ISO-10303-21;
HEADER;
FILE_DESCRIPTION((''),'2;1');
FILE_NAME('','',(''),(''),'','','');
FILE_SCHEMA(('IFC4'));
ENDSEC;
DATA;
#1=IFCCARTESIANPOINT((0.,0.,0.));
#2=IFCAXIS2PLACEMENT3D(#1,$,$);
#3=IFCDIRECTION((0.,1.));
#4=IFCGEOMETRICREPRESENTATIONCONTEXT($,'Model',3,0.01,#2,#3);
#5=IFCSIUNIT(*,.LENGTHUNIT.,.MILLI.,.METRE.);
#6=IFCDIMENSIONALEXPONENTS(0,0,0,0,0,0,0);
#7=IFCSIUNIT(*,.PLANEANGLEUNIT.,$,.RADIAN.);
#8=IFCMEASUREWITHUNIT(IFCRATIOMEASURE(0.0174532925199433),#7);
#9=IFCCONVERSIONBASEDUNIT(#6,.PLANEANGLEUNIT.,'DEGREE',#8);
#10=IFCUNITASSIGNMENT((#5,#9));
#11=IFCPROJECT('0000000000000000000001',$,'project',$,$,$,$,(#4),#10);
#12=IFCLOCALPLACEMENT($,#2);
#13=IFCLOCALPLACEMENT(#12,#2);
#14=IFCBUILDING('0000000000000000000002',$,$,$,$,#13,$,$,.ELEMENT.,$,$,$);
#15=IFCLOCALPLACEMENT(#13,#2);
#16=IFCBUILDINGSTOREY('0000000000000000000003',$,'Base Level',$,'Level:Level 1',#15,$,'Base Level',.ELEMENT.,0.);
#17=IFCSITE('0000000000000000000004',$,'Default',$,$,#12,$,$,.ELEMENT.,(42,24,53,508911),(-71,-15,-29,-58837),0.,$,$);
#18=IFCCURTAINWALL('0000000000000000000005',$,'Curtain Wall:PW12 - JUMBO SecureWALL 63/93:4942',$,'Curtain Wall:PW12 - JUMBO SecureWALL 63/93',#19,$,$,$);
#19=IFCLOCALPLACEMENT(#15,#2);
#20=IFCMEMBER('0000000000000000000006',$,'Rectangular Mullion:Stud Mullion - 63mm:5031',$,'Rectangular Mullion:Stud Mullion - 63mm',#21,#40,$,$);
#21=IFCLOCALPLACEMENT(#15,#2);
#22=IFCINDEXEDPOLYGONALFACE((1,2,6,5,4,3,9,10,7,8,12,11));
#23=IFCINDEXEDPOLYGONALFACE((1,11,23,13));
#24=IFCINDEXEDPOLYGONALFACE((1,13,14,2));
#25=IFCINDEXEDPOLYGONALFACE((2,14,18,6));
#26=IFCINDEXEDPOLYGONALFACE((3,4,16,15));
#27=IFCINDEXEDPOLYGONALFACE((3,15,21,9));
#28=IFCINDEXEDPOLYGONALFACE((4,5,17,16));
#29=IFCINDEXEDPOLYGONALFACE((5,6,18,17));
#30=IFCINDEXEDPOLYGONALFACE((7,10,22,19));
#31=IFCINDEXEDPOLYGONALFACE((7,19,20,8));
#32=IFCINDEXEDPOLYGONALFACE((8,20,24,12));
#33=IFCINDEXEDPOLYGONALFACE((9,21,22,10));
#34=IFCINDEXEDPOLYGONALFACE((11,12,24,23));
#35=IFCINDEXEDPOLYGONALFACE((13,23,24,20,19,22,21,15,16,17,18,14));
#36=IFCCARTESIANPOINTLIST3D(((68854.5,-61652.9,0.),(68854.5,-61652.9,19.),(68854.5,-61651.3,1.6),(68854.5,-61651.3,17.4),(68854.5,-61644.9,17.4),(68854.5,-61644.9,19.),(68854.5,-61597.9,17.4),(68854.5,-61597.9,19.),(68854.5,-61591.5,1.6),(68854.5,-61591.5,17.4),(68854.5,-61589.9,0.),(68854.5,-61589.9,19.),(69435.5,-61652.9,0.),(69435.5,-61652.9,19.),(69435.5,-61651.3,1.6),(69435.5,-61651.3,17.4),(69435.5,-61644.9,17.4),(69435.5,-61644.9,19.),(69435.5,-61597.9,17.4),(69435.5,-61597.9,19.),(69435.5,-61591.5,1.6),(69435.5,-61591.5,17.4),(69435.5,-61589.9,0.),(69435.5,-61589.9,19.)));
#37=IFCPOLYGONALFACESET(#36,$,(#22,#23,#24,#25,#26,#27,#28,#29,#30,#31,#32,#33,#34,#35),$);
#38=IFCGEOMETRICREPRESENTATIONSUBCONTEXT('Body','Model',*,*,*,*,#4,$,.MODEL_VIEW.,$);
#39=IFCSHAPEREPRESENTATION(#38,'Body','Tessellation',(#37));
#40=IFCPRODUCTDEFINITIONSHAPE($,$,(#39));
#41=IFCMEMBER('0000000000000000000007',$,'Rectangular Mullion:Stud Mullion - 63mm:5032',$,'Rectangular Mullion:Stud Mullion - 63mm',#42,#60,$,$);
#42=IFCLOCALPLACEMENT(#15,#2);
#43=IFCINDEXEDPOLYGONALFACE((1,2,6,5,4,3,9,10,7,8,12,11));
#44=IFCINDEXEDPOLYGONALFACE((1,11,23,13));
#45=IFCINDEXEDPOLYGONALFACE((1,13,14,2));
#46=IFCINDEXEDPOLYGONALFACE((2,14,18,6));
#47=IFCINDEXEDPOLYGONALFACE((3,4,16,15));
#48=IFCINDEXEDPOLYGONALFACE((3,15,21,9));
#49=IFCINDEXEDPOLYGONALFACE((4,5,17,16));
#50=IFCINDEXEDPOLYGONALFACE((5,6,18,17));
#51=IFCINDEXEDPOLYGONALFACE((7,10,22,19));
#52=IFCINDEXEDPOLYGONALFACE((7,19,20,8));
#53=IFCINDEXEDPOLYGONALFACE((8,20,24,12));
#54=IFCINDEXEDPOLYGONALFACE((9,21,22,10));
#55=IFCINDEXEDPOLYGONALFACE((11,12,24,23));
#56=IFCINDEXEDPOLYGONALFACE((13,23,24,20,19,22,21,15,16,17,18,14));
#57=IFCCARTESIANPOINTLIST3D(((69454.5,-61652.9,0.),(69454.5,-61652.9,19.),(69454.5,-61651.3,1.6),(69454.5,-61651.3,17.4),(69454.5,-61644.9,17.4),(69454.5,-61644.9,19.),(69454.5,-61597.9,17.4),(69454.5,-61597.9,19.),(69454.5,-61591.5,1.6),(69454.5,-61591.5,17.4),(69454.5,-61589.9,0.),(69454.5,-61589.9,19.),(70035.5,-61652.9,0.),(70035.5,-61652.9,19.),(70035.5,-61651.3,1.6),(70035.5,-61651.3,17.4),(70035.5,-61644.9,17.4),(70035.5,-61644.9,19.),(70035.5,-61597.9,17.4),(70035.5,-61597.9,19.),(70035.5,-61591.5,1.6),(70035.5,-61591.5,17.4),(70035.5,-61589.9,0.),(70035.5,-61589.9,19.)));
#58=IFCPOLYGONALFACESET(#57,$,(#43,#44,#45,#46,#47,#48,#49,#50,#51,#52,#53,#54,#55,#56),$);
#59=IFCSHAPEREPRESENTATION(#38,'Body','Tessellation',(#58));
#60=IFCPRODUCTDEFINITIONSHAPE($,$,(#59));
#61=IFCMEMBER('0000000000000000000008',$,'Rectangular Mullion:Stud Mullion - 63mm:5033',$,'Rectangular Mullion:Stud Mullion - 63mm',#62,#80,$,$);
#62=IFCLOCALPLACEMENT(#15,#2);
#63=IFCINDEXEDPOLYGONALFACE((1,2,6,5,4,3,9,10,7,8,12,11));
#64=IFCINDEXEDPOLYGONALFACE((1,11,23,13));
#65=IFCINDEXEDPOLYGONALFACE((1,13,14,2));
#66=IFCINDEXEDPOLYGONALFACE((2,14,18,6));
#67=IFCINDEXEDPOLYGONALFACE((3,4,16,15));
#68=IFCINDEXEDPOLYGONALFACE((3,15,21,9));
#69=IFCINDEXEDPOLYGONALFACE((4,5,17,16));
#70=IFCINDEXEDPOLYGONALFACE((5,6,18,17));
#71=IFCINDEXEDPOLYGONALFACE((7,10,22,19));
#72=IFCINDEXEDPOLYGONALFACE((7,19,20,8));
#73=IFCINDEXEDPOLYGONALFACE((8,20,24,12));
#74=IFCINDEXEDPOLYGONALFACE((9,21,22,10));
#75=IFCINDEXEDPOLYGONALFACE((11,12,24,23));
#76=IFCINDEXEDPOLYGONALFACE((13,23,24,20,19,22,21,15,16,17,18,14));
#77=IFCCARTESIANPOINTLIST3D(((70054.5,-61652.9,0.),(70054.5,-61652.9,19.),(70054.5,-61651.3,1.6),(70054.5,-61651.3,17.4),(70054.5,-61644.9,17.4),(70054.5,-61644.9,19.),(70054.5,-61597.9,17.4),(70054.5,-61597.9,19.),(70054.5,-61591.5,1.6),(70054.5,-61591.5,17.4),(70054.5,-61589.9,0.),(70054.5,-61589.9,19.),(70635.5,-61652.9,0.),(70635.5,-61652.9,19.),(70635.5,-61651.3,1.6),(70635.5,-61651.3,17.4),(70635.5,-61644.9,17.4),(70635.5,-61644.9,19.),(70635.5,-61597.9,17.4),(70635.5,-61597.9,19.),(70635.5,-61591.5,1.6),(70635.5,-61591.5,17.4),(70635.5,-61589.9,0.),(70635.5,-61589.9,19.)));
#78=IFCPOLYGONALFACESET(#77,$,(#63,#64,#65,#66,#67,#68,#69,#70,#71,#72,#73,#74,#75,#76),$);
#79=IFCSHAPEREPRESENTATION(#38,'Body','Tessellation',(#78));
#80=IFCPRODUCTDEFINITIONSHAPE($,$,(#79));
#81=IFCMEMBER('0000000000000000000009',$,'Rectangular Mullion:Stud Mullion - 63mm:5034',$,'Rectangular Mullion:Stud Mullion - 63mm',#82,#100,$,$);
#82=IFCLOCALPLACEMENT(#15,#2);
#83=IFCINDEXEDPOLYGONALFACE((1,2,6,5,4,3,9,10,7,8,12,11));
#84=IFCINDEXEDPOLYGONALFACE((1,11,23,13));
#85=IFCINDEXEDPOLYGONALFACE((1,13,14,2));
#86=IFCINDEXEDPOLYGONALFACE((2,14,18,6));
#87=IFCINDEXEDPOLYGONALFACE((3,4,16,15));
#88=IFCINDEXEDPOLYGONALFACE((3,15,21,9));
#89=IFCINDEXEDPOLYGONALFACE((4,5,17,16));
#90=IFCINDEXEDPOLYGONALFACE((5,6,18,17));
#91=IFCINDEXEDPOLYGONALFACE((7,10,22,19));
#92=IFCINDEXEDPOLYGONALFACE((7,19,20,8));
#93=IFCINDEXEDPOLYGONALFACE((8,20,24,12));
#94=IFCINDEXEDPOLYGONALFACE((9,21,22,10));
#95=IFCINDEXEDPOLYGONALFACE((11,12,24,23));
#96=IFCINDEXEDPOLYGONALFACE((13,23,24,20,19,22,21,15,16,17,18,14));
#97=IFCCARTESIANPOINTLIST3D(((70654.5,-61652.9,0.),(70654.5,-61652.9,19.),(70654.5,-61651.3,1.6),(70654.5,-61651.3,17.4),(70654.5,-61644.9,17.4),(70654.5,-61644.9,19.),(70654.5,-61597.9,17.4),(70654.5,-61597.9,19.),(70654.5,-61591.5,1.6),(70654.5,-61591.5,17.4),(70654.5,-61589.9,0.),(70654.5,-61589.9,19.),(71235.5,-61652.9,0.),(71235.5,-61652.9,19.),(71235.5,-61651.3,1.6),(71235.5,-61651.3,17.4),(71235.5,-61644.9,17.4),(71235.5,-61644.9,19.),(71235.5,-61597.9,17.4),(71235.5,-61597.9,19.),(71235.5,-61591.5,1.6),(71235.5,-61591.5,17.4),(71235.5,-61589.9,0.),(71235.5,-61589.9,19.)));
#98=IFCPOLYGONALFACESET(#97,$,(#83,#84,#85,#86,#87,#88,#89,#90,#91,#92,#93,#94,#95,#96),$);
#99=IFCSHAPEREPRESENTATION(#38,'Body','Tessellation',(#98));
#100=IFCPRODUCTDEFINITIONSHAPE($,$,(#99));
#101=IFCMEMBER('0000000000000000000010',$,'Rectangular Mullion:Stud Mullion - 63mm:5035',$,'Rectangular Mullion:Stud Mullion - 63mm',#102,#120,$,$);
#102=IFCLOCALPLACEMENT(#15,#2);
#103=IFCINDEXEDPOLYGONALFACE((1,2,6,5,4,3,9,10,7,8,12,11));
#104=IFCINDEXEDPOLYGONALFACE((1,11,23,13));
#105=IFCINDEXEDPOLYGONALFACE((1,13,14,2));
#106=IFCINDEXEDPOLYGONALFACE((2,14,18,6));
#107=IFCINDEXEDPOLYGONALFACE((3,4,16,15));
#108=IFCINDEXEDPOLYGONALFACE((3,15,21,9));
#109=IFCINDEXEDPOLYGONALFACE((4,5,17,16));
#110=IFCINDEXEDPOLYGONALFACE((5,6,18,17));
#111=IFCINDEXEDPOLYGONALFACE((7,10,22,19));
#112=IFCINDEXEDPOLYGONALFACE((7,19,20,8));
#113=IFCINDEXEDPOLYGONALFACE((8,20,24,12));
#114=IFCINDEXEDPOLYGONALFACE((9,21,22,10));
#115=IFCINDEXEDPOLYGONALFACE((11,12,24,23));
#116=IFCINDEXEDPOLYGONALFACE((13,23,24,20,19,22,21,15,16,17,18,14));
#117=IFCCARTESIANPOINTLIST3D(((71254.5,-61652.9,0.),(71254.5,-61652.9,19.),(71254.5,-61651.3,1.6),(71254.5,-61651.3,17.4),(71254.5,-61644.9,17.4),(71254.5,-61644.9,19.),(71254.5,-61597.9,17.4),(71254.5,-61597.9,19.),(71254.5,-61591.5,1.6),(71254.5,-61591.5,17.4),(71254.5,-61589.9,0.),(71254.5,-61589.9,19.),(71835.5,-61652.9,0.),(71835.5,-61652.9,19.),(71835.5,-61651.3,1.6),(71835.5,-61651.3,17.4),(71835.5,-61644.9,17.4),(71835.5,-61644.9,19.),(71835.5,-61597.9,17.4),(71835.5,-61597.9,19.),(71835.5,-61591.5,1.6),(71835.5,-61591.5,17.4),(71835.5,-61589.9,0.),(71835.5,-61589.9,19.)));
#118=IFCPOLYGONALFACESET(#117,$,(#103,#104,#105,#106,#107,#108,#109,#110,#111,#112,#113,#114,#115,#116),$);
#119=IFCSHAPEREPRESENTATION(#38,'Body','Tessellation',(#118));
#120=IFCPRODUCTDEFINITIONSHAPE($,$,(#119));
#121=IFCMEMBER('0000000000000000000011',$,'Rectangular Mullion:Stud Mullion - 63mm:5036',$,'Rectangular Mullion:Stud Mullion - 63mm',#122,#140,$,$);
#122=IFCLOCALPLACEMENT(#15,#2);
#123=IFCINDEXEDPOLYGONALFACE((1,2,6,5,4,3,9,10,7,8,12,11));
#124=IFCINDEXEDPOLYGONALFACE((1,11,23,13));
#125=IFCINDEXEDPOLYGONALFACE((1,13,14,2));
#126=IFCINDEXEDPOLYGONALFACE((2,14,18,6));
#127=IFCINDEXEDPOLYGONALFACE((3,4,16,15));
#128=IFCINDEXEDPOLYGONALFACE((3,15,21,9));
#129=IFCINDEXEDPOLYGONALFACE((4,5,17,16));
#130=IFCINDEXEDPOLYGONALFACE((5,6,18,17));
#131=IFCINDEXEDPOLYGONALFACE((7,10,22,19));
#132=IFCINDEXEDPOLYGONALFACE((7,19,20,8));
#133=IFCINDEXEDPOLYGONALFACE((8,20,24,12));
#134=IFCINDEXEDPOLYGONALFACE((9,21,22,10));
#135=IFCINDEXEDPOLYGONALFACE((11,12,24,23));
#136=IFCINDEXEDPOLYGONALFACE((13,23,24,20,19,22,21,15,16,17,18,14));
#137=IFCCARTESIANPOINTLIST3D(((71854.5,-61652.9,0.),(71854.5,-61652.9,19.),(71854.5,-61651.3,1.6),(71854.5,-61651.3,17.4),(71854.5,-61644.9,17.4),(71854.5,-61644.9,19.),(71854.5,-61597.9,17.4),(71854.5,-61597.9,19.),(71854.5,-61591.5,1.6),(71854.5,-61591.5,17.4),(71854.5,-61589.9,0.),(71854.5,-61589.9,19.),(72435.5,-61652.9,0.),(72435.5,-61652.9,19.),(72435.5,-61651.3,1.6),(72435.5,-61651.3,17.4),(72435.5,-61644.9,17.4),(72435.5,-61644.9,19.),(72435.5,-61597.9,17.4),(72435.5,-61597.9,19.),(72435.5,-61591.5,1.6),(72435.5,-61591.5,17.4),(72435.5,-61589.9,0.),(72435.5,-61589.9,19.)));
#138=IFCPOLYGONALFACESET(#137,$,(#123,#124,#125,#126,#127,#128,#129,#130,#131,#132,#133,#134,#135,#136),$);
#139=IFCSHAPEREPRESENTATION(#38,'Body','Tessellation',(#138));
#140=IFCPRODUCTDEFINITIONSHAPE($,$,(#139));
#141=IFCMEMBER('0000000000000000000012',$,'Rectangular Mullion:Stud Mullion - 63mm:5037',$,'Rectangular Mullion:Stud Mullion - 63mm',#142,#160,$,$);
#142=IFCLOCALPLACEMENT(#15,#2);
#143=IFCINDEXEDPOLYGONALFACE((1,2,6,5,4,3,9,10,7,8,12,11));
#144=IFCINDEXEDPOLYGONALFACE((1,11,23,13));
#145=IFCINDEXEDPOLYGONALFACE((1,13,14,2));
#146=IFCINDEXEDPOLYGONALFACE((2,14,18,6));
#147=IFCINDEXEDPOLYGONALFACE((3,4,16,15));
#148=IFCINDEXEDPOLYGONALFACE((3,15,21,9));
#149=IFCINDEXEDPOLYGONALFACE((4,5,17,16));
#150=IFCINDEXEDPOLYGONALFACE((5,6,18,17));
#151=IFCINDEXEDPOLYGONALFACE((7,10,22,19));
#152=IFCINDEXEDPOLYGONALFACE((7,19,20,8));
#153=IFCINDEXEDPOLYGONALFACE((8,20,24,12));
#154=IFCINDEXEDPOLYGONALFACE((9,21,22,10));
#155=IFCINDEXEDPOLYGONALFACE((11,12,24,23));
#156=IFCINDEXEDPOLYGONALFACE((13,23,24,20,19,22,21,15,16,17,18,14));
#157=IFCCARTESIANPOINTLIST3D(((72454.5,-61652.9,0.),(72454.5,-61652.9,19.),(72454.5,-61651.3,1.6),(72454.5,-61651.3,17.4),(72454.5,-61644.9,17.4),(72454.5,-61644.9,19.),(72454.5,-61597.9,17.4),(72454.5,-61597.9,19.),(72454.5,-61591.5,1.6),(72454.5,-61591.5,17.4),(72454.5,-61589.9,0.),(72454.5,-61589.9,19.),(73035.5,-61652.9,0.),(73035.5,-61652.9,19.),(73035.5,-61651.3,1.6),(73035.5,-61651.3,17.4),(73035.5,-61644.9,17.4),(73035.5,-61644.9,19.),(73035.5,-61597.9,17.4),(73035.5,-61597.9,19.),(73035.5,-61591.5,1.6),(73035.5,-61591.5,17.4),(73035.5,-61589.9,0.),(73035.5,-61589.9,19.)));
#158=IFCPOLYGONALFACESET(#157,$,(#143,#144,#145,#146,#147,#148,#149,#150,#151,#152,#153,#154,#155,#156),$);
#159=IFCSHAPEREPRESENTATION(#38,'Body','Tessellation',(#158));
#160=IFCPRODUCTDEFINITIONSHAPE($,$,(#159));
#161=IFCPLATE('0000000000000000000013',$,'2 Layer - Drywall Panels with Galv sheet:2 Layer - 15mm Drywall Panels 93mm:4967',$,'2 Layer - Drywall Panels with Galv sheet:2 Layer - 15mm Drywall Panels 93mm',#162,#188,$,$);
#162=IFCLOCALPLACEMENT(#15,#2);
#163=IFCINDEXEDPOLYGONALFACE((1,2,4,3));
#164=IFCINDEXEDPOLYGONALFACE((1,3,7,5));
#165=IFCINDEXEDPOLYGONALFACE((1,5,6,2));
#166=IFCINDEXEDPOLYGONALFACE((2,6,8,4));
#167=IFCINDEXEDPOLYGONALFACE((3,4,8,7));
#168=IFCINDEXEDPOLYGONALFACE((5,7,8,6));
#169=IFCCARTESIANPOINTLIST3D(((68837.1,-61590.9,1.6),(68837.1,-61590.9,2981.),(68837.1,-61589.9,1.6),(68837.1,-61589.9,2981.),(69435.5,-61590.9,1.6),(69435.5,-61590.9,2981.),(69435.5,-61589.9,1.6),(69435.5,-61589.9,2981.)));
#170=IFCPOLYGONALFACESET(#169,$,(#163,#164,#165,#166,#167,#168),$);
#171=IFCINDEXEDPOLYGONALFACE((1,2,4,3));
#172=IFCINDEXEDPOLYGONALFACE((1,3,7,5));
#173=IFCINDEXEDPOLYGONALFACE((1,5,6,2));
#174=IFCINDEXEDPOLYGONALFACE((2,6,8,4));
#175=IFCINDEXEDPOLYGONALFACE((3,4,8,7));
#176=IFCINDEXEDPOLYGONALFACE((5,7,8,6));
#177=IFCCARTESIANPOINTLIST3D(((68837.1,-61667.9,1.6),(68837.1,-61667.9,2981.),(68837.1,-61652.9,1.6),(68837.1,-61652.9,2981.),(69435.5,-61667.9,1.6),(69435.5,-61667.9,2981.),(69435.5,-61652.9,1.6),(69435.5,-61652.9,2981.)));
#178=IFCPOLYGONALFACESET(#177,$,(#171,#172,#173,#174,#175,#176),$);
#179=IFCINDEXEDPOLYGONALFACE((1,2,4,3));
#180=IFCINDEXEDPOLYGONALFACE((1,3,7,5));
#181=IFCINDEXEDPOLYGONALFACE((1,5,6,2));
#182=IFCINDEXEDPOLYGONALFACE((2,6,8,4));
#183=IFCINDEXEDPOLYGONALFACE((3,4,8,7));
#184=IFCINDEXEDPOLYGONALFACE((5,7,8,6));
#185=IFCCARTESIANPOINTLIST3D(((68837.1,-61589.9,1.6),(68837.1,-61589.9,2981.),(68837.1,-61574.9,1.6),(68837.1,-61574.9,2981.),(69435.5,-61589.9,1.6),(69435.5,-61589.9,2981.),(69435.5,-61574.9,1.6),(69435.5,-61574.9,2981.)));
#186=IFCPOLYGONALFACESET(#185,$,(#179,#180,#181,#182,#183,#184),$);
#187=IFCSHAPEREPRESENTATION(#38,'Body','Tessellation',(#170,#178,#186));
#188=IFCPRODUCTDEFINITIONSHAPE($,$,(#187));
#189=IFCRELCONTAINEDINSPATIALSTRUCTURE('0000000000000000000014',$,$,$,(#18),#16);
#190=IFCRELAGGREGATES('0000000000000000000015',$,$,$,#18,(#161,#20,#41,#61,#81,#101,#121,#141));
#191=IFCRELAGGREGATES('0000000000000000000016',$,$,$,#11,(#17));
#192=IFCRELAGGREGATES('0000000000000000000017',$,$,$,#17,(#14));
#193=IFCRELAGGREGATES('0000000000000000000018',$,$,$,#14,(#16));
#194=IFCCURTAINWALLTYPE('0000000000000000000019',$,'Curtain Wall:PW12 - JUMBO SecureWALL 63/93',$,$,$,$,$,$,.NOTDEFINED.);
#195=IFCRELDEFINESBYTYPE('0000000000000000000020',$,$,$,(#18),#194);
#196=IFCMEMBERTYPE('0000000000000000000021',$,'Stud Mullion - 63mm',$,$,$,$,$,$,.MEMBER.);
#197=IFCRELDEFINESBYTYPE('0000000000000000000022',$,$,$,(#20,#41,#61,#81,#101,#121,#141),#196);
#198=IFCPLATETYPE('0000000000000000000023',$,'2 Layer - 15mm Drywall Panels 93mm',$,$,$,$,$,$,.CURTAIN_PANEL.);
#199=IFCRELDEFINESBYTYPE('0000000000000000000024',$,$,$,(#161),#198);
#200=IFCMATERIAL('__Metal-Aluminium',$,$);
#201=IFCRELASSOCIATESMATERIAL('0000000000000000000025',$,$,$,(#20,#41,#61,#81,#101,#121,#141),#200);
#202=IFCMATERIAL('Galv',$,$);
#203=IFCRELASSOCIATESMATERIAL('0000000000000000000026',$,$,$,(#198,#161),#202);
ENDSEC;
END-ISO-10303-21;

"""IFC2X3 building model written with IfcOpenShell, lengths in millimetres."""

from ifc_helpers import new_model, entity, si_unit, converted_unit, direction, frame, frame_2d, origin, origin_2d_with_axis, place, context, subcontext, project, spatial, polyline, rectangle, outline, extrude, source, transform, mapped, material, type_object, type_shapes, element, aggregate, save


model = new_model("IFC2X3")

# Units and contexts
model_context = context("Model", 3, precision=0.01, world=origin(), true_north=direction((0.0, 1.0)))
body_context = subcontext(model_context, "Body", "Model", "MODEL_VIEW")
ifc_project = project(units=[si_unit("LENGTHUNIT", "METRE", prefix="MILLI"), converted_unit("PLANEANGLEUNIT", "DEGREE", entity("IfcRatioMeasure", 0.0174532925199433), si_unit("PLANEANGLEUNIT", "RADIAN"), dimensions=[0, 0, 0, 0, 0, 0, 0])], contexts=[model_context])

# Site, building, storey
site_placement = place(None, origin())
site = spatial("IfcSite", under=ifc_project, at=site_placement, Name="Default", CompositionType="ELEMENT", RefLatitude=(42, 24, 53, 508911), RefLongitude=(-71, -15, -29, -58837), RefElevation=0.0)
building_placement = place(site_placement, origin())
building = spatial("IfcBuilding", under=site, at=building_placement, CompositionType="ELEMENT")
storey_placement = place(building_placement, origin())
storey = spatial("IfcBuildingStorey", under=building, at=storey_placement, Name="Base Level", ObjectType="Level:Level 1", LongName="Base Level", CompositionType="ELEMENT", Elevation=0.0)

# Curtain wall, members, plate
curtain_wall_type = type_object("IfcCurtainWallType", Name="Curtain Wall:PW12 - JUMBO SecureWALL 63/93", PredefinedType="NOTDEFINED")
curtain_wall_placement = place(building_placement, origin())
curtain_wall = element("IfcCurtainWall", 1, at=curtain_wall_placement, inside=storey, type_object=curtain_wall_type, Name="Curtain Wall:PW12 - JUMBO SecureWALL 63/93:4942", ObjectType="Curtain Wall:PW12 - JUMBO SecureWALL 63/93")
ifc_material_1 = material(Name="__Metal-Aluminium")
member_type_1 = type_object("IfcMemberType", Name="Stud Mullion - 63mm", PredefinedType="MEMBER")
shared_shape_1 = source(origin(), body_context, "Body", "SweptSolid", [
    extrude(outline(polyline([(23.5, -6.6), (31.5, -6.6), (31.5, 12.4), (-31.5, 12.4), (-31.5, -6.6), (-23.5, -6.6), (-23.5, -5.0), (-29.9, -5.0), (-29.9, 10.8), (29.9, 10.8), (29.9, -5.0), (23.5, -5.0), (23.5, -6.6)])), frame((-12.4, 0.0, -581.0), z_axis=(0.0, 0.0, 1.0), x_axis=(0.0, -1.0, 0.0)), (0.0, 0.0, 1.0), 581.0),
])
type_shapes(member_type_1, [shared_shape_1])
member_1_placement = place(building_placement, frame((68854.5, -61621.4, 0.0), z_axis=(-1.0, 0.0, 0.0), x_axis=(0.0, 0.0, -1.0)))
member_1 = element("IfcMember", 2, at=member_1_placement, type_object=member_type_1, material=ifc_material_1, Name="Rectangular Mullion:Stud Mullion - 63mm:5031", ObjectType="Rectangular Mullion:Stud Mullion - 63mm", context=body_context, shape_type="MappedRepresentation", body=[
    mapped(shared_shape_1, transform((0.0, 0.0, 0.0), scale=1.0)),
])
member_2_placement = place(building_placement, frame((69454.5, -61621.4, 0.0), z_axis=(-1.0, 0.0, 0.0), x_axis=(0.0, 0.0, -1.0)))
member_2 = element("IfcMember", 3, at=member_2_placement, type_object=member_type_1, material=ifc_material_1, Name="Rectangular Mullion:Stud Mullion - 63mm:5032", ObjectType="Rectangular Mullion:Stud Mullion - 63mm", context=body_context, shape_type="MappedRepresentation", body=[
    mapped(shared_shape_1, transform((0.0, 0.0, 0.0), scale=1.0)),
])
member_3_placement = place(building_placement, frame((70054.5, -61621.4, 0.0), z_axis=(-1.0, 0.0, 0.0), x_axis=(0.0, 0.0, -1.0)))
member_3 = element("IfcMember", 4, at=member_3_placement, type_object=member_type_1, material=ifc_material_1, Name="Rectangular Mullion:Stud Mullion - 63mm:5033", ObjectType="Rectangular Mullion:Stud Mullion - 63mm", context=body_context, shape_type="MappedRepresentation", body=[
    mapped(shared_shape_1, transform((0.0, 0.0, 0.0), scale=1.0)),
])
member_4_placement = place(building_placement, frame((70654.5, -61621.4, 0.0), z_axis=(-1.0, 0.0, 0.0), x_axis=(0.0, 0.0, -1.0)))
member_4 = element("IfcMember", 5, at=member_4_placement, type_object=member_type_1, material=ifc_material_1, Name="Rectangular Mullion:Stud Mullion - 63mm:5034", ObjectType="Rectangular Mullion:Stud Mullion - 63mm", context=body_context, shape_type="MappedRepresentation", body=[
    mapped(shared_shape_1, transform((0.0, 0.0, 0.0), scale=1.0)),
])
member_5_placement = place(building_placement, frame((71254.5, -61621.4, 0.0), z_axis=(-1.0, 0.0, 0.0), x_axis=(0.0, 0.0, -1.0)))
member_5 = element("IfcMember", 6, at=member_5_placement, type_object=member_type_1, material=ifc_material_1, Name="Rectangular Mullion:Stud Mullion - 63mm:5035", ObjectType="Rectangular Mullion:Stud Mullion - 63mm", context=body_context, shape_type="MappedRepresentation", body=[
    mapped(shared_shape_1, transform((0.0, 0.0, 0.0), scale=1.0)),
])
member_6_placement = place(building_placement, frame((71854.5, -61621.4, 0.0), z_axis=(-1.0, 0.0, 0.0), x_axis=(0.0, 0.0, -1.0)))
member_6 = element("IfcMember", 7, at=member_6_placement, type_object=member_type_1, material=ifc_material_1, Name="Rectangular Mullion:Stud Mullion - 63mm:5036", ObjectType="Rectangular Mullion:Stud Mullion - 63mm", context=body_context, shape_type="MappedRepresentation", body=[
    mapped(shared_shape_1, transform((0.0, 0.0, 0.0), scale=1.0)),
])
member_7_placement = place(building_placement, frame((72454.5, -61621.4, 0.0), z_axis=(-1.0, 0.0, 0.0), x_axis=(0.0, 0.0, -1.0)))
member_7 = element("IfcMember", 8, at=member_7_placement, type_object=member_type_1, material=ifc_material_1, Name="Rectangular Mullion:Stud Mullion - 63mm:5037", ObjectType="Rectangular Mullion:Stud Mullion - 63mm", context=body_context, shape_type="MappedRepresentation", body=[
    mapped(shared_shape_1, transform((0.0, 0.0, 0.0), scale=1.0)),
])
ifc_material_2 = material(Name="Galv")
plate_type = type_object("IfcPlateType", Name="2 Layer - 15mm Drywall Panels 93mm", PredefinedType="CURTAIN_PANEL", material=ifc_material_2)
shared_shape_2 = source(origin(), body_context, "Body", "SweptSolid", [
    extrude(rectangle(XDim=598.4, YDim=1.0, at=origin_2d_with_axis()), frame((0.0, 31.0, 0.0), z_axis=(0.0, 0.0, 1.0), x_axis=(-1.0, 0.0, 0.0)), (0.0, 0.0, 1.0), 2979.4),
    extrude(rectangle(XDim=598.4, YDim=15.0, at=frame_2d((0.0, 0.0), x_axis=(1.0, 0.0))), frame((0.0, -39.0, 0.0), z_axis=(0.0, 0.0, 1.0), x_axis=(-1.0, 0.0, 0.0)), (0.0, 0.0, 1.0), 2979.4),
    extrude(rectangle(XDim=15.0, YDim=598.4, at=frame_2d((0.0, 0.0), x_axis=(1.0, 0.0))), frame((0.0, 39.0, 0.0), z_axis=(0.0, 0.0, 1.0), x_axis=(0.0, 1.0, 0.0)), (0.0, 0.0, 1.0), 2979.4),
])
type_shapes(plate_type, [shared_shape_2])
plate_1_placement = place(curtain_wall_placement, frame((69136.3, -61621.4, 1.6)))
plate_1 = element("IfcPlate", 9, at=plate_1_placement, type_object=plate_type, material=ifc_material_2, Name="2 Layer - Drywall Panels with Galv sheet:2 Layer - 15mm Drywall Panels 93mm:4967", ObjectType="2 Layer - Drywall Panels with Galv sheet:2 Layer - 15mm Drywall Panels 93mm", context=body_context, shape_type="MappedRepresentation", body=[
    mapped(shared_shape_2, transform((0.0, 0.0, 0.0), scale=1.0)),
])
aggregate(curtain_wall, [plate_1, member_1, member_2, member_3, member_4, member_5, member_6, member_7])

save(model, "model.ifc")
